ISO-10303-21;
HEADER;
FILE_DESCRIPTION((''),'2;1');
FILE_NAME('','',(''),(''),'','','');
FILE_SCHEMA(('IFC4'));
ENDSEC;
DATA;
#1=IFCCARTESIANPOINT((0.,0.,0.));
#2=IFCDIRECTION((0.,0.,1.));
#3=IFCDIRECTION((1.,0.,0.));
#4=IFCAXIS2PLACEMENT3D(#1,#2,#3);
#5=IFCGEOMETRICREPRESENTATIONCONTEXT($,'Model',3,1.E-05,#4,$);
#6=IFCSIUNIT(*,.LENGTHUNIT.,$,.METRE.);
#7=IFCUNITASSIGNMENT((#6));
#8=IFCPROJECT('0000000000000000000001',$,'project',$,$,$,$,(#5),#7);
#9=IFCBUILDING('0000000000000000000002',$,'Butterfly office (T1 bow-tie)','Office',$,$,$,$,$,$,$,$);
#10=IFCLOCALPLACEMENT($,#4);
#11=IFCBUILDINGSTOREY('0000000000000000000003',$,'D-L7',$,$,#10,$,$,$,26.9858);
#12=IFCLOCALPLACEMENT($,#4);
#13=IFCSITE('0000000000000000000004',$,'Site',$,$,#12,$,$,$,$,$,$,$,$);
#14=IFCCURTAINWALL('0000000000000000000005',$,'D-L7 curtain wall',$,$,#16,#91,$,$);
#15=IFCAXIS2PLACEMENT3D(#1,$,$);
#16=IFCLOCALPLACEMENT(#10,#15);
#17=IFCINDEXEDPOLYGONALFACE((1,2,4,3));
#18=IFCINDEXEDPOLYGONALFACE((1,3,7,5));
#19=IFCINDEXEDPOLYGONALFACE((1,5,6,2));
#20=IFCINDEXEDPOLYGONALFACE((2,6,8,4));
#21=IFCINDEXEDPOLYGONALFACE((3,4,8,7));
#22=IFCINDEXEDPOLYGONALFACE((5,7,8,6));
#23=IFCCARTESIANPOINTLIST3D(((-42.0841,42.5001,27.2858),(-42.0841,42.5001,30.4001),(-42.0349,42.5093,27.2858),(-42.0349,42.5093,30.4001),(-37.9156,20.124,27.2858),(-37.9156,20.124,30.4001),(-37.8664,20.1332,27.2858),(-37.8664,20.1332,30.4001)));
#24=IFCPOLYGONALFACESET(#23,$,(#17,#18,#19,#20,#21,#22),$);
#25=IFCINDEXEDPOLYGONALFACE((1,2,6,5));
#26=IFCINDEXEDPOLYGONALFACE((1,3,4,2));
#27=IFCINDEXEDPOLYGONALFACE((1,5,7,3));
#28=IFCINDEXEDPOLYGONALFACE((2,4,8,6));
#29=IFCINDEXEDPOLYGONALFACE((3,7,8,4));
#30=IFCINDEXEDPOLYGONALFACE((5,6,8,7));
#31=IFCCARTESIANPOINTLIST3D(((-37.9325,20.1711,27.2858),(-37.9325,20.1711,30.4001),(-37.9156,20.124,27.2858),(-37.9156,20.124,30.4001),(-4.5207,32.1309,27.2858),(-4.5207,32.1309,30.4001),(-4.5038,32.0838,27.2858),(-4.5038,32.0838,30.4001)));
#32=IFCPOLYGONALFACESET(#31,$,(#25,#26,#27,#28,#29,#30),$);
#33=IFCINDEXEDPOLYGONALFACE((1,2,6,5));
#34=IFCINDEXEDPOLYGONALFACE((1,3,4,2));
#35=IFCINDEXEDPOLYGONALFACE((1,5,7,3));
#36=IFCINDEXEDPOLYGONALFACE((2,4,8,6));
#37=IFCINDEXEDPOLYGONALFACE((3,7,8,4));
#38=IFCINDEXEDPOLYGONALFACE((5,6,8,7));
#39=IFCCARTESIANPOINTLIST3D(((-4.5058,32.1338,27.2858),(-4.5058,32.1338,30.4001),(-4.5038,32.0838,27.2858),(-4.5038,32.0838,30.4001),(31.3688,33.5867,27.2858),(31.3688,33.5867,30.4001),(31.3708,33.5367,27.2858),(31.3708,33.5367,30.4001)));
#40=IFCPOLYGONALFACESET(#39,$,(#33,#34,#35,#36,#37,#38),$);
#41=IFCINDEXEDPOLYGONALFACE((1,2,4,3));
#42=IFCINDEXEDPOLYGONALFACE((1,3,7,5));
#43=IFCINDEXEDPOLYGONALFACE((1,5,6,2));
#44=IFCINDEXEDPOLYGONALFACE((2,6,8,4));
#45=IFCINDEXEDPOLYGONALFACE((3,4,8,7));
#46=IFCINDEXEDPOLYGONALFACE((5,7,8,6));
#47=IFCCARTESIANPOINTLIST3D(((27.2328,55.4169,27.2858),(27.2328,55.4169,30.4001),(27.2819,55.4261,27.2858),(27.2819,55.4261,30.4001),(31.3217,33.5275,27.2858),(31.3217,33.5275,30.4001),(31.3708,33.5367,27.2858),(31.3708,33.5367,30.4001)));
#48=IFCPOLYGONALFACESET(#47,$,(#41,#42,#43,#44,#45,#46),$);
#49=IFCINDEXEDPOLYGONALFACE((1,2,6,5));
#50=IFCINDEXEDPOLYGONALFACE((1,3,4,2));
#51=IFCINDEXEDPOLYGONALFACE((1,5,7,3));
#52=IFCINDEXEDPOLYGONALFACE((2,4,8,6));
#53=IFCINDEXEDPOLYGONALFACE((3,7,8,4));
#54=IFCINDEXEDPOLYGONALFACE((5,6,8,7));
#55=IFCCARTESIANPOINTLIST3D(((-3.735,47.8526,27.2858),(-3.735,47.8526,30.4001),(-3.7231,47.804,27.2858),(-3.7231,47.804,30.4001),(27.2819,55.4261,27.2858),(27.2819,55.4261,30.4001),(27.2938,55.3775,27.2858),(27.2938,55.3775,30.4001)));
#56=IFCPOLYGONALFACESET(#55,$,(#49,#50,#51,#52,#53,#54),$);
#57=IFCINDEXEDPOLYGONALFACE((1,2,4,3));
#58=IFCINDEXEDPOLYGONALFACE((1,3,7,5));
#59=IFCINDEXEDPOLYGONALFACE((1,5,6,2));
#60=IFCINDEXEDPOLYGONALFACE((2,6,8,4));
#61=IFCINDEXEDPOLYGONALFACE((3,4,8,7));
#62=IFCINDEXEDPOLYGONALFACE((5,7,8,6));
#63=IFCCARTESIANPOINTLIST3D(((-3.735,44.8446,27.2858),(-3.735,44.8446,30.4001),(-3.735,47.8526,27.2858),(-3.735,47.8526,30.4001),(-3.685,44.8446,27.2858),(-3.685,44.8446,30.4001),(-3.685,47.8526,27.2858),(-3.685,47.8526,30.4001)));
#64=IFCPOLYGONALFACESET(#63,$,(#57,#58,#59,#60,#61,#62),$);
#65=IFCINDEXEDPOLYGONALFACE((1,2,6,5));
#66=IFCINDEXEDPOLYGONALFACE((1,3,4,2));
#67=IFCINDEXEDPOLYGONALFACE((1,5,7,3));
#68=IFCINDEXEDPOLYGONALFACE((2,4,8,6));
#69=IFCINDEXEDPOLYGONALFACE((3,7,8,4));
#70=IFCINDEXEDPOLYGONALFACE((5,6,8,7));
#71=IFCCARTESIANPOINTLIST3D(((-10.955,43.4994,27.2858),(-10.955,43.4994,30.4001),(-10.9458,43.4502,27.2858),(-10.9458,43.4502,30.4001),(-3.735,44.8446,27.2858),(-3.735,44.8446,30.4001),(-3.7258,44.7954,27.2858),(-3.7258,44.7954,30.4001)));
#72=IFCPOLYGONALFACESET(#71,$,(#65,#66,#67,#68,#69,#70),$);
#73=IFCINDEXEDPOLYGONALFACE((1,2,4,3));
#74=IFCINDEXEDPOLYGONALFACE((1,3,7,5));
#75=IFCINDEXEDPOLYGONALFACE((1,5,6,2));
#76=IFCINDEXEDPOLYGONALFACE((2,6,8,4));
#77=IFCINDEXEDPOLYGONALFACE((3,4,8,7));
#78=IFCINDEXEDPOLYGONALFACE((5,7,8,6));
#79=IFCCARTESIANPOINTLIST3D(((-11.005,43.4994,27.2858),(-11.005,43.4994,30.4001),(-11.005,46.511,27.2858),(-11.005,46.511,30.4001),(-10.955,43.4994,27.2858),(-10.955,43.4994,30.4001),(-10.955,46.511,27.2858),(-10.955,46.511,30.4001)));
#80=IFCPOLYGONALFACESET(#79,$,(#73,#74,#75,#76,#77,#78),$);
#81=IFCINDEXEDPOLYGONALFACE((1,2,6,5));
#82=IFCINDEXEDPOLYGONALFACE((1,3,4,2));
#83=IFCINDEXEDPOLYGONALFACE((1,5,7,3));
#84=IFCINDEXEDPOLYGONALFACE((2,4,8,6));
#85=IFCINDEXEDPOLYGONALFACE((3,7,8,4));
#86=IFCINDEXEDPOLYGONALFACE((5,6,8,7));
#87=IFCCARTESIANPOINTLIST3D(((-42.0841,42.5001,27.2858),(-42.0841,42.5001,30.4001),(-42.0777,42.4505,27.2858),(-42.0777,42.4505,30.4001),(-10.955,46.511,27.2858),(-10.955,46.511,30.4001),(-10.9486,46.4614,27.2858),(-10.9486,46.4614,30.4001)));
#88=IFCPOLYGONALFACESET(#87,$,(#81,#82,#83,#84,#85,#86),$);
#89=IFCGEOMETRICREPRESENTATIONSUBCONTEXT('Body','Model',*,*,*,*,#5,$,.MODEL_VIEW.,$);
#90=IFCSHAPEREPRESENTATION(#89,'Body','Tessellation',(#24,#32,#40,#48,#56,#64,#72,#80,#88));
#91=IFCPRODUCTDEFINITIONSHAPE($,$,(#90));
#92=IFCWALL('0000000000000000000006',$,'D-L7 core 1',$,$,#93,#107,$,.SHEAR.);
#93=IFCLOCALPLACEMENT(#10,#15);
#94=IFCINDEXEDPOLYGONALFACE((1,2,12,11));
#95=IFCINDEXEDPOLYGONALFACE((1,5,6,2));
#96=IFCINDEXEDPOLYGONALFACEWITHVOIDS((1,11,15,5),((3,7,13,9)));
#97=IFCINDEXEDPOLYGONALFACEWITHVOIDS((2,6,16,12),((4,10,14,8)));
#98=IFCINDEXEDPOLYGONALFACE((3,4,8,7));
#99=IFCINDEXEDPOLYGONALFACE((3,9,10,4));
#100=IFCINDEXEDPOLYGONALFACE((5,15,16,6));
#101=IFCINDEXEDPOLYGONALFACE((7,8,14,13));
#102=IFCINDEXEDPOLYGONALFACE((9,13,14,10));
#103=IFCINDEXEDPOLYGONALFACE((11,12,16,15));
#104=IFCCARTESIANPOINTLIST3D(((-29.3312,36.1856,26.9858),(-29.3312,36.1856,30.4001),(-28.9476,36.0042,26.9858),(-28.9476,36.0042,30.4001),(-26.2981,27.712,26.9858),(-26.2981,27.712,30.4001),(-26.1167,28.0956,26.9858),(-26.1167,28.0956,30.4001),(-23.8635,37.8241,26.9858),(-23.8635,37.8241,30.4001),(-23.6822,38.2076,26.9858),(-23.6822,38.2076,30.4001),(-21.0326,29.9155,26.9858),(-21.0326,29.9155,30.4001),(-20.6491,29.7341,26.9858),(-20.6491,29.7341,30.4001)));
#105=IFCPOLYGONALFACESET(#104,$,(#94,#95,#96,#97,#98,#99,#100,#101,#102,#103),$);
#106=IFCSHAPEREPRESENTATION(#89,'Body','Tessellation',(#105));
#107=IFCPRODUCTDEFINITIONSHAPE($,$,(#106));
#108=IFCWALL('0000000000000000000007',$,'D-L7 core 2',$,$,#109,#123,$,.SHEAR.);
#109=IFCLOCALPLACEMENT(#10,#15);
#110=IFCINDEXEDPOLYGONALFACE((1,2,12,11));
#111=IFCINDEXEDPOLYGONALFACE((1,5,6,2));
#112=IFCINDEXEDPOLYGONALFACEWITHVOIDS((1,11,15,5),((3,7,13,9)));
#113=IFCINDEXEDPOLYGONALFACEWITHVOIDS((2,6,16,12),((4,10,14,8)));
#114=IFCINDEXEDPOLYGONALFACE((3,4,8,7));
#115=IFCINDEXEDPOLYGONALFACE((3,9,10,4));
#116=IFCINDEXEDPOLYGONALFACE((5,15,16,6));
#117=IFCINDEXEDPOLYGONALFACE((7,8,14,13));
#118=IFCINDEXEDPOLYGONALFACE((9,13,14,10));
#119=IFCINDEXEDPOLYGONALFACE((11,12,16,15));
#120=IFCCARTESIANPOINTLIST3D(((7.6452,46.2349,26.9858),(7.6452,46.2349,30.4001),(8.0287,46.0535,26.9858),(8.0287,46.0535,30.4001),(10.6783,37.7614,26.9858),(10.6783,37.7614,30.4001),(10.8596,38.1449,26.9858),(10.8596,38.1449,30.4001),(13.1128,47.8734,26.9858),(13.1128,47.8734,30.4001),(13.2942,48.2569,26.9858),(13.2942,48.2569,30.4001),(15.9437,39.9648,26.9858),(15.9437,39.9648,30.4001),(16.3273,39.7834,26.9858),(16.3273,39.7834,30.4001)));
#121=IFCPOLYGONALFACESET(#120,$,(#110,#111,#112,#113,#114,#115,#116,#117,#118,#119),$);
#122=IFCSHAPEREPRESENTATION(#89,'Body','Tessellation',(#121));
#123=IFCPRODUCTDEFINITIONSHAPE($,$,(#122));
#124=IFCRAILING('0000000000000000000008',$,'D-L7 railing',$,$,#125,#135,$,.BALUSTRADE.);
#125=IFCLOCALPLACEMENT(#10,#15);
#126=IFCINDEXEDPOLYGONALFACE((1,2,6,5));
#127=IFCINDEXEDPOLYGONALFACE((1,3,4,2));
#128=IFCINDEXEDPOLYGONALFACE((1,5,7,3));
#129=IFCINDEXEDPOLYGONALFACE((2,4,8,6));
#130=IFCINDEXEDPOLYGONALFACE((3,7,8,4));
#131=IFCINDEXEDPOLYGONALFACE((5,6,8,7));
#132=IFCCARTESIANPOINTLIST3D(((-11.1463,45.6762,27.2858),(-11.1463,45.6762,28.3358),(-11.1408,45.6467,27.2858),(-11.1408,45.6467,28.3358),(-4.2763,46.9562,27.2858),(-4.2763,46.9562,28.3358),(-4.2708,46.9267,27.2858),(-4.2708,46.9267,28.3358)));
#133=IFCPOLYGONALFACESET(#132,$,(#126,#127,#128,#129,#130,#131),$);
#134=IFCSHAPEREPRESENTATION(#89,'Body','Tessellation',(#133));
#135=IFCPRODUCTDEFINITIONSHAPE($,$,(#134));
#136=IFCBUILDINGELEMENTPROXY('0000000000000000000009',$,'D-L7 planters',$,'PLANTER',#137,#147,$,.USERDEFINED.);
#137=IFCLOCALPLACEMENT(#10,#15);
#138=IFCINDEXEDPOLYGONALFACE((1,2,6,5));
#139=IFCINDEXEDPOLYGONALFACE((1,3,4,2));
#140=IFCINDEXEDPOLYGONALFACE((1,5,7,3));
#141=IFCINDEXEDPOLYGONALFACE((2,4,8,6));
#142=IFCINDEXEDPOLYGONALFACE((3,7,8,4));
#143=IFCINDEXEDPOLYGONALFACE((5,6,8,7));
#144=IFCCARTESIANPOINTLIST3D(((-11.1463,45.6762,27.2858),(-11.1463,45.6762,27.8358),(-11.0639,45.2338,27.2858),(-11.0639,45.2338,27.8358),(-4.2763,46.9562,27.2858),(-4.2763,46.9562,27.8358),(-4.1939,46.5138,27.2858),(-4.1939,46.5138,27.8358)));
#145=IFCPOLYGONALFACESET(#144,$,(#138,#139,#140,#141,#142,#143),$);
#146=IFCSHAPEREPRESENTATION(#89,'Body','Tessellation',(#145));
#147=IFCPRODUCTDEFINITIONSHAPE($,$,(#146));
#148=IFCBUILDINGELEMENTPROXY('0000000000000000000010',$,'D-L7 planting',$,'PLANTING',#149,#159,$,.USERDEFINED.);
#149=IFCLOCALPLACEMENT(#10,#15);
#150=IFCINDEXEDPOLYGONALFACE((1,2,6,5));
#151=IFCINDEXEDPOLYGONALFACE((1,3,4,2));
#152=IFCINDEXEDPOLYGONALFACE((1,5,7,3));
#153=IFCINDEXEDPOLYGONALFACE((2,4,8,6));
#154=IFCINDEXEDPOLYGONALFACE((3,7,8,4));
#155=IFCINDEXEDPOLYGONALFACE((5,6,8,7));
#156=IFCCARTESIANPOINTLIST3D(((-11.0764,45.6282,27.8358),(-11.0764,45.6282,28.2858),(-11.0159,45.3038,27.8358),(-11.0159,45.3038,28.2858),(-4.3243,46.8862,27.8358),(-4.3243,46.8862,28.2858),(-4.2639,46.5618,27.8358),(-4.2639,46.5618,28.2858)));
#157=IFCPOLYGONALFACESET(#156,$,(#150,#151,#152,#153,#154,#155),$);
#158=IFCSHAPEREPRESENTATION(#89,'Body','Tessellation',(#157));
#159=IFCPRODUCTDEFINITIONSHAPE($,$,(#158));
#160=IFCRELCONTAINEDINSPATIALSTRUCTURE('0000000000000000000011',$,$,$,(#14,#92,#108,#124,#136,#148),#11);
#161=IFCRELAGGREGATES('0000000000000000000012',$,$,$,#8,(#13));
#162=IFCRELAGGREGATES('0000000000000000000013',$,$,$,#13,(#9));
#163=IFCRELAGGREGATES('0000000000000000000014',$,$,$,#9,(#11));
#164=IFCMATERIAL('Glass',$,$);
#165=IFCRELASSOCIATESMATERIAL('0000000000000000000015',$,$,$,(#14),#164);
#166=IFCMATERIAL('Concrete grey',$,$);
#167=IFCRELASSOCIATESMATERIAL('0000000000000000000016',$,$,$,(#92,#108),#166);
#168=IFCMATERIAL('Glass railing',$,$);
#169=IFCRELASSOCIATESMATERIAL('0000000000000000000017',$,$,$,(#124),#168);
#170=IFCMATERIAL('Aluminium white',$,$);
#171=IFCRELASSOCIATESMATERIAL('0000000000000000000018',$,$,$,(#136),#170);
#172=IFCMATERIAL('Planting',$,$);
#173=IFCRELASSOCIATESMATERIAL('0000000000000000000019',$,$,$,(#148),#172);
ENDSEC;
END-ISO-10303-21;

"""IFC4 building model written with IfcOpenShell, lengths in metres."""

from ifc_helpers import new_model, si_unit, frame, origin_with_axes, place, context, subcontext, project, spatial, polyline, outline, extrude, material, element, save


model = new_model("IFC4")

# Units and contexts
model_context = context("Model", 3, precision=1e-05, world=origin_with_axes())
body_context = subcontext(model_context, "Body", "Model", "MODEL_VIEW")
ifc_project = project(units=[si_unit("LENGTHUNIT", "METRE")], contexts=[model_context])

# Site, building, storey
site_placement = place(None, origin_with_axes())
site = spatial("IfcSite", under=ifc_project, at=site_placement, Name="Site")
building = spatial("IfcBuilding", under=site, Name="Butterfly office (T1 bow-tie)", Description="Office")
storey_placement = place(None, origin_with_axes())
storey = spatial("IfcBuildingStorey", under=building, at=storey_placement, Name="D-L7", Elevation=26.9858)

# Shared definitions
ifc_material_1 = material(Name="Concrete grey")

# Shared definitions
ifc_material_2 = material(Name="Aluminium white")

# Curtain wall
ifc_material_3 = material(Name="Glass")
curtain_wall_placement = place(storey_placement, origin_with_axes())
element("IfcCurtainWall", 1, at=curtain_wall_placement, inside=storey, material=ifc_material_3, Name="D-L7 curtain wall", context=body_context, shape_type="SweptSolid", body=[
    extrude(outline(polyline([(-42.0841, 42.5001), (-37.9156, 20.124), (-37.8664, 20.1332), (-42.0349, 42.5093), (-42.0841, 42.5001)])), frame((0.0, 0.0, 27.2858), z_axis=(0.0, 0.0, 1.0), x_axis=(1.0, 0.0, 0.0)), (0.0, 0.0, 1.0), 3.1143),
    extrude(outline(polyline([(-37.9156, 20.124), (-4.5038, 32.0838), (-4.5207, 32.1309), (-37.9325, 20.1711), (-37.9156, 20.124)])), frame((0.0, 0.0, 27.2858), z_axis=(0.0, 0.0, 1.0), x_axis=(1.0, 0.0, 0.0)), (0.0, 0.0, 1.0), 3.1143),
    extrude(outline(polyline([(-4.5038, 32.0838), (31.3708, 33.5367), (31.3688, 33.5867), (-4.5058, 32.1338), (-4.5038, 32.0838)])), frame((0.0, 0.0, 27.2858), z_axis=(0.0, 0.0, 1.0), x_axis=(1.0, 0.0, 0.0)), (0.0, 0.0, 1.0), 3.1143),
    extrude(outline(polyline([(31.3708, 33.5367), (27.2819, 55.4261), (27.2328, 55.4169), (31.3217, 33.5275), (31.3708, 33.5367)])), frame((0.0, 0.0, 27.2858), z_axis=(0.0, 0.0, 1.0), x_axis=(1.0, 0.0, 0.0)), (0.0, 0.0, 1.0), 3.1143),
    extrude(outline(polyline([(27.2819, 55.4261), (-3.735, 47.8526), (-3.7231, 47.804), (27.2938, 55.3775), (27.2819, 55.4261)])), frame((0.0, 0.0, 27.2858), z_axis=(0.0, 0.0, 1.0), x_axis=(1.0, 0.0, 0.0)), (0.0, 0.0, 1.0), 3.1143),
    extrude(outline(polyline([(-3.735, 47.8526), (-3.735, 44.8446), (-3.685, 44.8446), (-3.685, 47.8526), (-3.735, 47.8526)])), frame((0.0, 0.0, 27.2858), z_axis=(0.0, 0.0, 1.0), x_axis=(1.0, 0.0, 0.0)), (0.0, 0.0, 1.0), 3.1143),
    extrude(outline(polyline([(-3.735, 44.8446), (-10.955, 43.4994), (-10.9458, 43.4502), (-3.7258, 44.7954), (-3.735, 44.8446)])), frame((0.0, 0.0, 27.2858), z_axis=(0.0, 0.0, 1.0), x_axis=(1.0, 0.0, 0.0)), (0.0, 0.0, 1.0), 3.1143),
    extrude(outline(polyline([(-10.955, 43.4994), (-10.955, 46.511), (-11.005, 46.511), (-11.005, 43.4994), (-10.955, 43.4994)])), frame((0.0, 0.0, 27.2858), z_axis=(0.0, 0.0, 1.0), x_axis=(1.0, 0.0, 0.0)), (0.0, 0.0, 1.0), 3.1143),
    extrude(outline(polyline([(-10.955, 46.511), (-42.0841, 42.5001), (-42.0777, 42.4505), (-10.9486, 46.4614), (-10.955, 46.511)])), frame((0.0, 0.0, 27.2858), z_axis=(0.0, 0.0, 1.0), x_axis=(1.0, 0.0, 0.0)), (0.0, 0.0, 1.0), 3.1143),
])

# Walls
wall_1_placement = place(storey_placement, origin_with_axes())
element("IfcWall", 2, at=wall_1_placement, inside=storey, material=ifc_material_1, Name="D-L7 core 1", PredefinedType="SHEAR", context=body_context, shape_type="SweptSolid", body=[
    extrude(outline(polyline([(-26.2981, 27.712), (-20.6491, 29.7341), (-23.6822, 38.2076), (-29.3312, 36.1856), (-26.2981, 27.712)]), holes=[polyline([(-26.1167, 28.0956), (-21.0326, 29.9155), (-23.8635, 37.8241), (-28.9476, 36.0042), (-26.1167, 28.0956)])]), frame((0.0, 0.0, 26.9858), z_axis=(0.0, 0.0, 1.0), x_axis=(1.0, 0.0, 0.0)), (0.0, 0.0, 1.0), 3.4143),
])
wall_2_placement = place(storey_placement, origin_with_axes())
element("IfcWall", 3, at=wall_2_placement, inside=storey, material=ifc_material_1, Name="D-L7 core 2", PredefinedType="SHEAR", context=body_context, shape_type="SweptSolid", body=[
    extrude(outline(polyline([(10.6783, 37.7614), (16.3273, 39.7834), (13.2942, 48.2569), (7.6452, 46.2349), (10.6783, 37.7614)]), holes=[polyline([(10.8596, 38.1449), (15.9437, 39.9648), (13.1128, 47.8734), (8.0287, 46.0535), (10.8596, 38.1449)])]), frame((0.0, 0.0, 26.9858), z_axis=(0.0, 0.0, 1.0), x_axis=(1.0, 0.0, 0.0)), (0.0, 0.0, 1.0), 3.4143),
])

# Railing
ifc_material_4 = material(Name="Glass railing")
railing_placement = place(storey_placement, origin_with_axes())
element("IfcRailing", 4, at=railing_placement, inside=storey, material=ifc_material_4, Name="D-L7 railing", PredefinedType="BALUSTRADE", context=body_context, shape_type="SweptSolid", body=[
    extrude(outline(polyline([(-4.2763, 46.9562), (-11.1463, 45.6762), (-11.1408, 45.6467), (-4.2708, 46.9267), (-4.2763, 46.9562)])), frame((0.0, 0.0, 27.2858), z_axis=(0.0, 0.0, 1.0), x_axis=(1.0, 0.0, 0.0)), (0.0, 0.0, 1.0), 1.05),
])

# Building element proxies
proxy_1_placement = place(storey_placement, origin_with_axes())
element("IfcBuildingElementProxy", 5, at=proxy_1_placement, inside=storey, material=ifc_material_2, Name="D-L7 planters", ObjectType="PLANTER", PredefinedType="USERDEFINED", context=body_context, shape_type="SweptSolid", body=[
    extrude(outline(polyline([(-4.2763, 46.9562), (-11.1463, 45.6762), (-11.0639, 45.2338), (-4.1939, 46.5138), (-4.2763, 46.9562)])), frame((0.0, 0.0, 27.2858), z_axis=(0.0, 0.0, 1.0), x_axis=(1.0, 0.0, 0.0)), (0.0, 0.0, 1.0), 0.55),
])
ifc_material_5 = material(Name="Planting")
proxy_2_placement = place(storey_placement, origin_with_axes())
element("IfcBuildingElementProxy", 6, at=proxy_2_placement, inside=storey, material=ifc_material_5, Name="D-L7 planting", ObjectType="PLANTING", PredefinedType="USERDEFINED", context=body_context, shape_type="SweptSolid", body=[
    extrude(outline(polyline([(-4.3243, 46.8862), (-11.0764, 45.6282), (-11.0159, 45.3038), (-4.2639, 46.5618), (-4.3243, 46.8862)])), frame((0.0, 0.0, 27.8358), z_axis=(0.0, 0.0, 1.0), x_axis=(1.0, 0.0, 0.0)), (0.0, 0.0, 1.0), 0.45),
])

save(model, "model.ifc")
